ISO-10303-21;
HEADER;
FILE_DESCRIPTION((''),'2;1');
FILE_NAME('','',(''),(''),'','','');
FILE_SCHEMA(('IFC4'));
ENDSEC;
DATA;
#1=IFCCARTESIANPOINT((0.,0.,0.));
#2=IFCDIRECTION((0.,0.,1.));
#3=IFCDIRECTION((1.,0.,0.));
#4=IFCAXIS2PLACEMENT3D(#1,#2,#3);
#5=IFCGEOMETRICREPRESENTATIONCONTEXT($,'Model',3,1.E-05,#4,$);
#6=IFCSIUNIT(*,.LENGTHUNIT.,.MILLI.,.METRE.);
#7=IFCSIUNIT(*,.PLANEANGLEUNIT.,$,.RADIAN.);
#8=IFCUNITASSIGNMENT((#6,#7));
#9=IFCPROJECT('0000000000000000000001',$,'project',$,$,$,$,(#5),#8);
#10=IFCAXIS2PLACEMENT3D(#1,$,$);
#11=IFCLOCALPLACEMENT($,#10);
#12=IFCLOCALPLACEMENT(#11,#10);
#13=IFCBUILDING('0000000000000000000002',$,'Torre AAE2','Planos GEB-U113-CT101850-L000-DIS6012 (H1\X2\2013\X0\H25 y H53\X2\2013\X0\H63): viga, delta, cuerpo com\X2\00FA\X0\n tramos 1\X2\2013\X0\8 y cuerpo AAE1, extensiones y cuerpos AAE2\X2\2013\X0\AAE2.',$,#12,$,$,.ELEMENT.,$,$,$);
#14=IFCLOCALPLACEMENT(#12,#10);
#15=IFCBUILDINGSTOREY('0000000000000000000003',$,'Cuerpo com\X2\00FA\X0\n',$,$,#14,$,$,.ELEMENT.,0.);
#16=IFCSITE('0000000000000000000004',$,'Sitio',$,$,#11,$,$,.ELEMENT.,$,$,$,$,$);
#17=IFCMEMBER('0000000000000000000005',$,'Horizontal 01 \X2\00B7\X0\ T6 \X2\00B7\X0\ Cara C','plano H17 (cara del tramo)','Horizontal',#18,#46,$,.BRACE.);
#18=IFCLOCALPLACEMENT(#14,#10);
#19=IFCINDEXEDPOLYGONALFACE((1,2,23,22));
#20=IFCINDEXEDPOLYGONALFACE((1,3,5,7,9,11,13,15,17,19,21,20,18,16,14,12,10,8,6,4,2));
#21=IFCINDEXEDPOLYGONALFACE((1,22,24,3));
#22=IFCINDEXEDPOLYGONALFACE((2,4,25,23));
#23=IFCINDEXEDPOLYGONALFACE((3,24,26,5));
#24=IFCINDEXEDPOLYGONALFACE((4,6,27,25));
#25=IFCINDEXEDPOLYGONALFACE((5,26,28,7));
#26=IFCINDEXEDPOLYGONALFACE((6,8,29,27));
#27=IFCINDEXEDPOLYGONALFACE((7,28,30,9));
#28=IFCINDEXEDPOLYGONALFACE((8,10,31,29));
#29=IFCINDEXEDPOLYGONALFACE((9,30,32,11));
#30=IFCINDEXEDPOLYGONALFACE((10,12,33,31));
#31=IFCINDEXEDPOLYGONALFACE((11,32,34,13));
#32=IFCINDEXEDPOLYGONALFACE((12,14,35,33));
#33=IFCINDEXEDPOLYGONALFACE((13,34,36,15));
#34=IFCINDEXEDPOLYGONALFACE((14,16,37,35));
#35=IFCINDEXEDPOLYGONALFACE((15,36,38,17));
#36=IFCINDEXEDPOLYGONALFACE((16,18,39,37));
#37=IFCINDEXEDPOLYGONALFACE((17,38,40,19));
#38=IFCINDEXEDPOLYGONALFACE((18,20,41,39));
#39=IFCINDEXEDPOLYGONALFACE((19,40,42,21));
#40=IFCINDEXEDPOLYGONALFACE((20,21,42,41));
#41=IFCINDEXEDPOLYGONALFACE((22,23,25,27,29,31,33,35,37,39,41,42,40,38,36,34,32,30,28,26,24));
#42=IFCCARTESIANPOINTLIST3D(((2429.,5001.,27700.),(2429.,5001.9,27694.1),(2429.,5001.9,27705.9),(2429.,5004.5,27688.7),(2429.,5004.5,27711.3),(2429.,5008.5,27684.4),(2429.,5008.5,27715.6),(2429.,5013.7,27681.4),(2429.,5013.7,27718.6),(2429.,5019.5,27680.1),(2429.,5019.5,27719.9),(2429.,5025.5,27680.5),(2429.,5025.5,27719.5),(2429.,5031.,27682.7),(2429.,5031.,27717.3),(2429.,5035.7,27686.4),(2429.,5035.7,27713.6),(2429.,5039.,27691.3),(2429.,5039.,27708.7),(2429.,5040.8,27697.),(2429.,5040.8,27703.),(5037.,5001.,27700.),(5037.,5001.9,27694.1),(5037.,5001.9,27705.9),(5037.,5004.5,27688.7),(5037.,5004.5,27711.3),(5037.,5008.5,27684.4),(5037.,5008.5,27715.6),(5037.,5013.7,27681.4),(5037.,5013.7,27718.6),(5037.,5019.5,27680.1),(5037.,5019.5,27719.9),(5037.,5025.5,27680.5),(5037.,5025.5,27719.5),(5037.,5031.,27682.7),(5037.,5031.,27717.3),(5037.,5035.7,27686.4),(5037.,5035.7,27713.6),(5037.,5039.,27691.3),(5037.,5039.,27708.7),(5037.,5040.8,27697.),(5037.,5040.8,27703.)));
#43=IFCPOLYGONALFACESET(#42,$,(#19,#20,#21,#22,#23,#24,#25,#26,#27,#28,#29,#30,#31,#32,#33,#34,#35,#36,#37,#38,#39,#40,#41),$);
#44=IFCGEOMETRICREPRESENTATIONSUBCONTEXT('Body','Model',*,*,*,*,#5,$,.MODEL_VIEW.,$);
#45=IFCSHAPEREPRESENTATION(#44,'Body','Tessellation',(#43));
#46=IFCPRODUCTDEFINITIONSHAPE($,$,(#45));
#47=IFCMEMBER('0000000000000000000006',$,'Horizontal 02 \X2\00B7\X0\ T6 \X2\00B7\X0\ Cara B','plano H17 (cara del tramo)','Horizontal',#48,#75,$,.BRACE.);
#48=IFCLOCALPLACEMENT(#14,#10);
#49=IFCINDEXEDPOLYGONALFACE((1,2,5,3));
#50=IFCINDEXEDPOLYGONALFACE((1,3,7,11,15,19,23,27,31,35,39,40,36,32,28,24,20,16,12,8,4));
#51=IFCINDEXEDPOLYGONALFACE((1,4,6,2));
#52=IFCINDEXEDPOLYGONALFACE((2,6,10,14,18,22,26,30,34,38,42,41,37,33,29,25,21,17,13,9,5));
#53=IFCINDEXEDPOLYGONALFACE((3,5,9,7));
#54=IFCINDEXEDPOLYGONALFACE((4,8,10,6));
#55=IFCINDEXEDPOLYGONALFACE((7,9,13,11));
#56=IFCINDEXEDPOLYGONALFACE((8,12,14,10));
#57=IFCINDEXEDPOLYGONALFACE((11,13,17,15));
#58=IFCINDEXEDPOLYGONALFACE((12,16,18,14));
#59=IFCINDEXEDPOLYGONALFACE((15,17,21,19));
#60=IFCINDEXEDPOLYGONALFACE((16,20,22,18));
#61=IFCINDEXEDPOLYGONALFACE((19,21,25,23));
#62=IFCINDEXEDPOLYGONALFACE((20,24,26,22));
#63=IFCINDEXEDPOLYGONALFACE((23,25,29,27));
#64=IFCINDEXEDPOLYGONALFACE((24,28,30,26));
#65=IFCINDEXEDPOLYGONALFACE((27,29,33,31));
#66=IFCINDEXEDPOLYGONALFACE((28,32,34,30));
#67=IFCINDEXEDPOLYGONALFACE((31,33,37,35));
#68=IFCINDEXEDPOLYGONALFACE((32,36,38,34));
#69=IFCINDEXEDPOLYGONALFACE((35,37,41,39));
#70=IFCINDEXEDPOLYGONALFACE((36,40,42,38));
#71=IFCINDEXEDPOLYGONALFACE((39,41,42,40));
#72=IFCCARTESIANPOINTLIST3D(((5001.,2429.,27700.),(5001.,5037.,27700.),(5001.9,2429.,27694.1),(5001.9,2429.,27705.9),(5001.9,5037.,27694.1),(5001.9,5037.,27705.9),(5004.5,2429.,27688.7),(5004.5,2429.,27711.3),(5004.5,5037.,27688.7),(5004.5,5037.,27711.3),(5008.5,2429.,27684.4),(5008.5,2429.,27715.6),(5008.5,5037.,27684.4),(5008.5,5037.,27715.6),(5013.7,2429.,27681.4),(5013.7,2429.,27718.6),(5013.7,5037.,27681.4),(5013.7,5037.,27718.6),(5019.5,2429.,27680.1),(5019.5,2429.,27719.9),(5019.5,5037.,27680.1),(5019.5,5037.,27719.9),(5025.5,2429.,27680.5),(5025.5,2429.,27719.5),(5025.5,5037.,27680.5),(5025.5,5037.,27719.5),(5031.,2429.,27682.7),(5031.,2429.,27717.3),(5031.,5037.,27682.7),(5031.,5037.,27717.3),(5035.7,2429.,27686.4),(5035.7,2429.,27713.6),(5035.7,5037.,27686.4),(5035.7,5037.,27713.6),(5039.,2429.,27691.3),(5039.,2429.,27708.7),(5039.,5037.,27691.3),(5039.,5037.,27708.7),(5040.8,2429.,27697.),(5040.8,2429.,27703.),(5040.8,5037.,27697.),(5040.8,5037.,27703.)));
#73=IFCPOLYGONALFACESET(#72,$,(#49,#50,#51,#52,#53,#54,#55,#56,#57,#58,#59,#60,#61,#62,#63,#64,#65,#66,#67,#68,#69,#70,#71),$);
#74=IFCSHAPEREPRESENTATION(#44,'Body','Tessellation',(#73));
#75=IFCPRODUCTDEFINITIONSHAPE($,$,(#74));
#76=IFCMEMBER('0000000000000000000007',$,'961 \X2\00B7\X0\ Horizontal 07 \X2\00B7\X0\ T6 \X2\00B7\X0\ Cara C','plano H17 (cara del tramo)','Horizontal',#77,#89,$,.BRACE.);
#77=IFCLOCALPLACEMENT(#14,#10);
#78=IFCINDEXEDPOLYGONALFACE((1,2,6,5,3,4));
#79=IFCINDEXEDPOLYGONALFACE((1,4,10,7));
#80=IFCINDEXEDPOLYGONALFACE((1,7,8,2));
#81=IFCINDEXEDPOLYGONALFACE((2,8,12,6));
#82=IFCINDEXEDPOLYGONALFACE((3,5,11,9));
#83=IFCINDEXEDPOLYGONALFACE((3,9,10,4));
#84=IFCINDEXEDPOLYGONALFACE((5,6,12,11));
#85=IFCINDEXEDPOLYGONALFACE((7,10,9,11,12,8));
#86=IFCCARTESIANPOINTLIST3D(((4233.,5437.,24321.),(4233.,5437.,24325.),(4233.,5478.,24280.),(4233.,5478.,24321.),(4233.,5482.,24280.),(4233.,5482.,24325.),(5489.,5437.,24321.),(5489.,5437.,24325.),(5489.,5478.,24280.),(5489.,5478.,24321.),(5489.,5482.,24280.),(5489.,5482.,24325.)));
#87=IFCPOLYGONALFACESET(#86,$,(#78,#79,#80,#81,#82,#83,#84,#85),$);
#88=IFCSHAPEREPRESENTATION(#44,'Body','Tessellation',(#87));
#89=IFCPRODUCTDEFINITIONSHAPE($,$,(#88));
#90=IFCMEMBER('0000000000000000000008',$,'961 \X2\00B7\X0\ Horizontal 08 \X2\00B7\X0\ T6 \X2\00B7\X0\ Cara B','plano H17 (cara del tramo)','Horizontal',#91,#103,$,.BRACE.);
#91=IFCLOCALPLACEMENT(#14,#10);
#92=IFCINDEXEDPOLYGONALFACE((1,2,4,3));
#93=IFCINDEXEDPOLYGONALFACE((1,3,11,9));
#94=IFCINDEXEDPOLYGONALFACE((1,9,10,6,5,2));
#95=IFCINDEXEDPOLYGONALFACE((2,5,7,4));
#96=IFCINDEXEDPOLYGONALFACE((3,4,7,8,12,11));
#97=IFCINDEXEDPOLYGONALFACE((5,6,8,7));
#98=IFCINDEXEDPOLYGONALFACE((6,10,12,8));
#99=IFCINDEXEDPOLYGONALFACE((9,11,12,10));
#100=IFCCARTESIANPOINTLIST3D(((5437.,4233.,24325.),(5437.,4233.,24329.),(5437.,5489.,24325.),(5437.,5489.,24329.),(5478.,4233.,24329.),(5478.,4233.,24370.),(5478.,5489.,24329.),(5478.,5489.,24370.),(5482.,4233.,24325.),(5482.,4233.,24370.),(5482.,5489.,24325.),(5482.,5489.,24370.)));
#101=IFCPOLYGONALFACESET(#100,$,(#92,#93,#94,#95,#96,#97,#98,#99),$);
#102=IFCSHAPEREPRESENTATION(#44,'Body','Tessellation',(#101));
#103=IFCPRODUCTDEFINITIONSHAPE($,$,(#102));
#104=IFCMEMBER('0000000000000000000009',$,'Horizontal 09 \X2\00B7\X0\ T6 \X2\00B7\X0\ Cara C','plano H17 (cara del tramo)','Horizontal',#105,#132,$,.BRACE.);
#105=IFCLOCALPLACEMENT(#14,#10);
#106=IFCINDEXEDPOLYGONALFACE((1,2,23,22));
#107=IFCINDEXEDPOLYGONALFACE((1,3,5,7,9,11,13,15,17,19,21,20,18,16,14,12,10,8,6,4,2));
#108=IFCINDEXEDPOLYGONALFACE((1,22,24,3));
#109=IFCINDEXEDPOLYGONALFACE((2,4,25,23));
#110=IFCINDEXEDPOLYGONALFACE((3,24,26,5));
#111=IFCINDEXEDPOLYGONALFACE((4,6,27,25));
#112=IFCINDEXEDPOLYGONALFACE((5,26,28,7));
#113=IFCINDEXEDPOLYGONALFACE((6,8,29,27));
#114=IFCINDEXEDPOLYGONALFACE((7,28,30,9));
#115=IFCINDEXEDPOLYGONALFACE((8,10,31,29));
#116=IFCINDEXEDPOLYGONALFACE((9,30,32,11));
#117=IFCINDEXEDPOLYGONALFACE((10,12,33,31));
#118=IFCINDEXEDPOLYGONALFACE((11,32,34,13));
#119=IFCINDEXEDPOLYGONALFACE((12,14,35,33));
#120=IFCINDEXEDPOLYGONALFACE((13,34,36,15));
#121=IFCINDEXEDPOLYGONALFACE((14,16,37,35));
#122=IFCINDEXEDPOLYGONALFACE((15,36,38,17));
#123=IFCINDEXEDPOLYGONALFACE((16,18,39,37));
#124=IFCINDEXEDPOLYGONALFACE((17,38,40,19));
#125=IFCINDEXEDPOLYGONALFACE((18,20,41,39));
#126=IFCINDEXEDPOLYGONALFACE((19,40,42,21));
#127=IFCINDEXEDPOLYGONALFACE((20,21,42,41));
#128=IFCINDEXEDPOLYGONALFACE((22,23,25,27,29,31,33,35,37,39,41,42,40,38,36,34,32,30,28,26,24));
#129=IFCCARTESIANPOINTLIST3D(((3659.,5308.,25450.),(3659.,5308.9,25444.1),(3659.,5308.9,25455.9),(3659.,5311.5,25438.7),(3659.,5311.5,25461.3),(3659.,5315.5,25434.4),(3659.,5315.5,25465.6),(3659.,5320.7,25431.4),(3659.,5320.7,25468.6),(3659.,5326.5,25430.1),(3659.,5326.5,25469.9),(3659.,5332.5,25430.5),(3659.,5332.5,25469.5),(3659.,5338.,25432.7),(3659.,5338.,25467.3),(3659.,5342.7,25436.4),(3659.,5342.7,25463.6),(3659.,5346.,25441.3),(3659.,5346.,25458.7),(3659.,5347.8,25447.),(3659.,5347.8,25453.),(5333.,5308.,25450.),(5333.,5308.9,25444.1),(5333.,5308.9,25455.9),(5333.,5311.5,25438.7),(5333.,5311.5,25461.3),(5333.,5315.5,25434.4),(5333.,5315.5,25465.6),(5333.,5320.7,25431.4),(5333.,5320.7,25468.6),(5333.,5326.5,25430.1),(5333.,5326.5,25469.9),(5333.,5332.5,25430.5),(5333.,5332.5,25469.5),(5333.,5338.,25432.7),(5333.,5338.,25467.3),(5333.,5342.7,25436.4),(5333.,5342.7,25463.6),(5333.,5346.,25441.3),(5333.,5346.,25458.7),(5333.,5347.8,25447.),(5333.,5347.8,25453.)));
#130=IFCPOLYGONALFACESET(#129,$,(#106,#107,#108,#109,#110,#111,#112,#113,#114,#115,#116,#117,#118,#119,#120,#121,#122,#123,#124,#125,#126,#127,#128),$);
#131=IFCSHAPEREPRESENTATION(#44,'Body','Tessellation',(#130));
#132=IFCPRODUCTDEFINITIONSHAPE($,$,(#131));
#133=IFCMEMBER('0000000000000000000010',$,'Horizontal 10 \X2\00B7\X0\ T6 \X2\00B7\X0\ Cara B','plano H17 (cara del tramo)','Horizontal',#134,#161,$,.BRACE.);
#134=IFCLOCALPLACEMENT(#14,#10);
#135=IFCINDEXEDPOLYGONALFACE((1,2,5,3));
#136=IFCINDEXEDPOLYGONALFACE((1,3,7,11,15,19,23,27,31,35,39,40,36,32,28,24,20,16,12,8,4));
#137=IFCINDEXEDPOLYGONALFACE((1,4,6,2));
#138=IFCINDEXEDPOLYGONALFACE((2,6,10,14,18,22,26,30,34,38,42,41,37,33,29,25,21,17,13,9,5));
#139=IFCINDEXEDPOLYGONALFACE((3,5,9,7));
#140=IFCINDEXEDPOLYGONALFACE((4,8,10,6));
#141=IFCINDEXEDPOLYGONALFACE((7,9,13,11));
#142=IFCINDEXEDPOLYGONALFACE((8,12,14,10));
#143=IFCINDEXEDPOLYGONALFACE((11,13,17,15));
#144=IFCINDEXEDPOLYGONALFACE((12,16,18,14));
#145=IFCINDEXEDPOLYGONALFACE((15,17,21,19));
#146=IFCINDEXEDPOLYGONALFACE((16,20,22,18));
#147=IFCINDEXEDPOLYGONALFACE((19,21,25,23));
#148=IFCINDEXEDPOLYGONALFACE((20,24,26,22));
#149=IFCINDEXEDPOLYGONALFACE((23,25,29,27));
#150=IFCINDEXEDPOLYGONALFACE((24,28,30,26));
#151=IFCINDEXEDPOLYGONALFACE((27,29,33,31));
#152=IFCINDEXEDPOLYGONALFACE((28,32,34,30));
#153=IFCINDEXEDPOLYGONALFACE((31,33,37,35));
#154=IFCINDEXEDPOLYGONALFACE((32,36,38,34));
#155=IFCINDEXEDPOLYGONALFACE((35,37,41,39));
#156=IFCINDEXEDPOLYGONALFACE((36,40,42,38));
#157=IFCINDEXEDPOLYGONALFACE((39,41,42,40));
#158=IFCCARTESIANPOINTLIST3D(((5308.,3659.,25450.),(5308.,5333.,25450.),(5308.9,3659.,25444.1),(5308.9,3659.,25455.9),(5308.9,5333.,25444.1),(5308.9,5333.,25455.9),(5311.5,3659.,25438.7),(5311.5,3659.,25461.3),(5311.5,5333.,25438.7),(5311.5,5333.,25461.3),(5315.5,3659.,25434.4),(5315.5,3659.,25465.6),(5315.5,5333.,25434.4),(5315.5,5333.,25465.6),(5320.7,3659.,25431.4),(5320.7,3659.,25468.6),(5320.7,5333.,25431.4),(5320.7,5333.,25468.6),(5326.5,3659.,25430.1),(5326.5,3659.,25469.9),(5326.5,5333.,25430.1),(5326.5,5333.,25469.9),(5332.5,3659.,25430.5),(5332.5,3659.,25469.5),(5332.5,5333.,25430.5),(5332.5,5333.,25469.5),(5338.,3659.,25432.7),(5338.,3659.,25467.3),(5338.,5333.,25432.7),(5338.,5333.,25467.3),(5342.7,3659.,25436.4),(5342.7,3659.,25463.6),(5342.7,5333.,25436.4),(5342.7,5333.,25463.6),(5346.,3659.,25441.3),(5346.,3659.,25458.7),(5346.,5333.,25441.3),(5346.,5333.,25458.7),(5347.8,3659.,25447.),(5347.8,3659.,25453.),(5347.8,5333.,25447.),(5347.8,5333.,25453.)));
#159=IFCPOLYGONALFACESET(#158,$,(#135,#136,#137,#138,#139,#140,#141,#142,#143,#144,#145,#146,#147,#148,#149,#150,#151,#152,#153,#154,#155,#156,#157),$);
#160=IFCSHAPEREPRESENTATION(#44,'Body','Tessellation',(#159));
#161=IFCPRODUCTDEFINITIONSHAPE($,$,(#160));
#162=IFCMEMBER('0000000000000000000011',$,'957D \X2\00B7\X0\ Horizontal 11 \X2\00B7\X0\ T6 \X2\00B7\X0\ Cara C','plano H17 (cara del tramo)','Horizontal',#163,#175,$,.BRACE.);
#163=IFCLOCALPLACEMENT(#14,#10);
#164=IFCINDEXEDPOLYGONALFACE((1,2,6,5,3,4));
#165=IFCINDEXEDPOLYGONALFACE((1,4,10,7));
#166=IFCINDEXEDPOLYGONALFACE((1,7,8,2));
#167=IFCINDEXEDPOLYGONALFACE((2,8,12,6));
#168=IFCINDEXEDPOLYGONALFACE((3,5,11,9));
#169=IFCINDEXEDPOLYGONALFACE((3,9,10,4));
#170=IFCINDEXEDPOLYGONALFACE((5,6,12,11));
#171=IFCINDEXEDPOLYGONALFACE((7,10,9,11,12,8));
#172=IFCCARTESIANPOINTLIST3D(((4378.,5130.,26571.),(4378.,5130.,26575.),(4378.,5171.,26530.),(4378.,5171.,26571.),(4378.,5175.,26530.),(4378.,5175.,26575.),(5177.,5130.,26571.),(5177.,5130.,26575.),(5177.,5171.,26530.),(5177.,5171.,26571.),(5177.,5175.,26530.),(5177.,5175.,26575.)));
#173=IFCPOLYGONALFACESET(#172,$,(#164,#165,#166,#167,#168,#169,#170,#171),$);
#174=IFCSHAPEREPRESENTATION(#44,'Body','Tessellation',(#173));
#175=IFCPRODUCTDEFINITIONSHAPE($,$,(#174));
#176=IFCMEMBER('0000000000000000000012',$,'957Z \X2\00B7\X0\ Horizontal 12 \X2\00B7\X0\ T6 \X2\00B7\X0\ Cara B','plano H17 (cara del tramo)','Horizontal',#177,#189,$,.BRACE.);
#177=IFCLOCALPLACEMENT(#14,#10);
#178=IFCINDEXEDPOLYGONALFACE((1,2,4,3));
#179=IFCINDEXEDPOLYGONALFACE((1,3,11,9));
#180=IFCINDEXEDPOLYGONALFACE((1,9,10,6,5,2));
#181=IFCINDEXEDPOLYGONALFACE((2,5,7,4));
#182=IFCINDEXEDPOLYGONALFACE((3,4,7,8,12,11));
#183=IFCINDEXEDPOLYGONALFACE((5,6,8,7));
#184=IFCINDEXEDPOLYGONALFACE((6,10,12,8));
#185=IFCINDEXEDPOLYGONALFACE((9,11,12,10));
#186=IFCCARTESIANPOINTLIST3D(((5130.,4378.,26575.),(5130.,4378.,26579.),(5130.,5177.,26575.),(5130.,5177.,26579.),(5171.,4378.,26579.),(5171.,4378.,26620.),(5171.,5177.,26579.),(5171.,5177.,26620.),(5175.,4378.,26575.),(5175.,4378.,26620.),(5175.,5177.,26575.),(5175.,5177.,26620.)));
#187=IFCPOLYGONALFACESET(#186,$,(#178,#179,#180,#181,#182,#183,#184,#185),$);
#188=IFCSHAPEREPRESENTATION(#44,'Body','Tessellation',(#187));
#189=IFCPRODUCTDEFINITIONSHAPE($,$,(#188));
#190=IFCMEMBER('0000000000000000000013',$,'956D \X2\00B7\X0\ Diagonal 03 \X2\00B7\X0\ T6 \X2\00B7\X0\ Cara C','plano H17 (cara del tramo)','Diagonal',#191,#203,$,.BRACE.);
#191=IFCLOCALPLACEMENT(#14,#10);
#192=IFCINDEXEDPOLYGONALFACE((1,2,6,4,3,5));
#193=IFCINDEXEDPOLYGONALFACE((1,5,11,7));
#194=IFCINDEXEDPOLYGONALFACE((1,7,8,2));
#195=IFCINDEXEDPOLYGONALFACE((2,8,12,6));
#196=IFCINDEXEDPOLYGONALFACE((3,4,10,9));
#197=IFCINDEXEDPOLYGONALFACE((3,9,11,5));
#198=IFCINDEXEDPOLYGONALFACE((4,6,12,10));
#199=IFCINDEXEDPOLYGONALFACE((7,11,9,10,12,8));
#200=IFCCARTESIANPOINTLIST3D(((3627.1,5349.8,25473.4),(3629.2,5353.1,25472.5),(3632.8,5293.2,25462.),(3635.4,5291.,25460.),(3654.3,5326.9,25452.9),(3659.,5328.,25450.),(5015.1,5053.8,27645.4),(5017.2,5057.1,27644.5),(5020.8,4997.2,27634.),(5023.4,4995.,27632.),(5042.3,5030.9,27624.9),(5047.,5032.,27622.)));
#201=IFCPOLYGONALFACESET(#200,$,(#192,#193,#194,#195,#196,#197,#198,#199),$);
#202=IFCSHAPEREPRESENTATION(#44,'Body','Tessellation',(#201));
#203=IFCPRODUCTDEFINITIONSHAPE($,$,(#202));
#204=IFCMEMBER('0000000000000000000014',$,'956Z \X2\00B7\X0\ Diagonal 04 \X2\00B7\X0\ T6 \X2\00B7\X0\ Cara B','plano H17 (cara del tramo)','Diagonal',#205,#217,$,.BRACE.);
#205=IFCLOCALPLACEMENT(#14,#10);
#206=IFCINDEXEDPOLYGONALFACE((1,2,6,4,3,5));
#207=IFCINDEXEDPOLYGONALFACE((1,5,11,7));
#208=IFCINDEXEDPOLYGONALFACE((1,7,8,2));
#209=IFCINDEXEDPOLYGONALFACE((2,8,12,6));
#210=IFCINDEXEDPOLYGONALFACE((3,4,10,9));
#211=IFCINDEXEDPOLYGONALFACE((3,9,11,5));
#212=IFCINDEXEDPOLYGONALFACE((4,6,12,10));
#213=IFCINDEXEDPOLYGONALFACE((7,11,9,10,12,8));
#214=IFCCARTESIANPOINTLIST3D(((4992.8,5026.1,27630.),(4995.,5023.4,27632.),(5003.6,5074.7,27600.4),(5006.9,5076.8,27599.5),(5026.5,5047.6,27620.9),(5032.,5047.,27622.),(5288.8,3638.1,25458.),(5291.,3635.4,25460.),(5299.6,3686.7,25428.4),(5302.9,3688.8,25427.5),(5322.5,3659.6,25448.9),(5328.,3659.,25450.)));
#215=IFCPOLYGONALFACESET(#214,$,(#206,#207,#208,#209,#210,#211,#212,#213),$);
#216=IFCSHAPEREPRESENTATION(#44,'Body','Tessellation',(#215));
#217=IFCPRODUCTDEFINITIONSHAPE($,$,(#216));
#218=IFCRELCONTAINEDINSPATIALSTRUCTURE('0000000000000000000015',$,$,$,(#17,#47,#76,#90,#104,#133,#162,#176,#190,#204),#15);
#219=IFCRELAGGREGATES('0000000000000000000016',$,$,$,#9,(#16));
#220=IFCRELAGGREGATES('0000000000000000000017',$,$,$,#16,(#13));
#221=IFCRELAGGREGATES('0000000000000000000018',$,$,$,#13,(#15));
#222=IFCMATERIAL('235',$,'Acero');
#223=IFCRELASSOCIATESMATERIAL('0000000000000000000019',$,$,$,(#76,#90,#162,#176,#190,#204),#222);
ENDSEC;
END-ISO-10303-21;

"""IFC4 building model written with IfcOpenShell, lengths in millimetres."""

from ifc_helpers import new_model, si_unit, frame, frame_2d, origin, origin_with_axes, place, context, subcontext, project, spatial, circle, l_section, extrude, material, element, save


model = new_model("IFC4")

# Units and contexts
model_context = context("Model", 3, precision=1e-05, world=origin_with_axes())
body_context = subcontext(model_context, "Body", "Model", "MODEL_VIEW")
ifc_project = project(units=[si_unit("LENGTHUNIT", "METRE", prefix="MILLI"), si_unit("PLANEANGLEUNIT", "RADIAN")], contexts=[model_context])

# Site, building, storey
site_placement = place(None, origin())
site = spatial("IfcSite", under=ifc_project, at=site_placement, Name="Sitio", CompositionType="ELEMENT")
building_placement = place(site_placement, origin())
building = spatial("IfcBuilding", under=site, at=building_placement, Name="Torre AAE2", Description="Planos GEB-U113-CT101850-L000-DIS6012 (H1–H25 y H53–H63): viga, delta, cuerpo común tramos 1–8 y cuerpo AAE1, extensiones y cuerpos AAE2–AAE2.", CompositionType="ELEMENT")
storey_placement = place(building_placement, origin())
storey = spatial("IfcBuildingStorey", under=building, at=storey_placement, Name="Cuerpo común", CompositionType="ELEMENT", Elevation=0.0)

# Members
for number, where, z_axis, x_axis, name in (
    (1, (5037.0, 5021.0, 27700.0), (-1.0, 0.0, 0.0), (0.0, -1.0, 0.0), "Horizontal 01 · T6 · Cara C"),
    (2, (5021.0, 5037.0, 27700.0), (0.0, -1.0, 0.0), (-1.0, 0.0, 0.0), "Horizontal 02 · T6 · Cara B"),
):
    element("IfcMember", number, at=place(storey_placement, frame(where, z_axis=z_axis, x_axis=x_axis)), inside=storey, Name=name, Description="plano H17 (cara del tramo)", ObjectType="Horizontal", PredefinedType="BRACE", context=body_context, shape_type="SweptSolid", body=[
        extrude(circle(Radius=20.0), None, (0.0, 0.0, 1.0), 2608.0),
    ])
ifc_material_1 = material(Name="235", Category="Acero")
for number, where, z_axis, x_axis, name in (
    (3, (4233.0, 5482.0, 24325.0), (1.0, 0.0, 0.0), (0.0, -1.0, 0.0), "961 · Horizontal 07 · T6 · Cara C"),
    (4, (5482.0, 4233.0, 24325.0), (0.0, 1.0, 0.0), (-1.0, 0.0, 0.0), "961 · Horizontal 08 · T6 · Cara B"),
):
    element("IfcMember", number, at=place(storey_placement, frame(where, z_axis=z_axis, x_axis=x_axis)), inside=storey, material=ifc_material_1, Name=name, Description="plano H17 (cara del tramo)", ObjectType="Horizontal", PredefinedType="BRACE", context=body_context, shape_type="SweptSolid", body=[
        extrude(l_section(Depth=45.0, Width=45.0, Thickness=4.0, at=frame_2d((22.5, 22.5))), None, (0.0, 0.0, 1.0), 1256.0),
    ])
for number, where, z_axis, x_axis, name in (
    (5, (3659.0, 5328.0, 25450.0), (1.0, 0.0, 0.0), (0.0, -1.0, 0.0), "Horizontal 09 · T6 · Cara C"),
    (6, (5328.0, 3659.0, 25450.0), (0.0, 1.0, 0.0), (-1.0, 0.0, 0.0), "Horizontal 10 · T6 · Cara B"),
):
    element("IfcMember", number, at=place(storey_placement, frame(where, z_axis=z_axis, x_axis=x_axis)), inside=storey, Name=name, Description="plano H17 (cara del tramo)", ObjectType="Horizontal", PredefinedType="BRACE", context=body_context, shape_type="SweptSolid", body=[
        extrude(circle(Radius=20.0), None, (0.0, 0.0, 1.0), 1674.0),
    ])
for number, where, z_axis, x_axis, name in (
    (7, (4378.0, 5175.0, 26575.0), (1.0, 0.0, 0.0), (0.0, -1.0, 0.0), "957D · Horizontal 11 · T6 · Cara C"),
    (8, (5175.0, 4378.0, 26575.0), (0.0, 1.0, 0.0), (-1.0, 0.0, 0.0), "957Z · Horizontal 12 · T6 · Cara B"),
):
    element("IfcMember", number, at=place(storey_placement, frame(where, z_axis=z_axis, x_axis=x_axis)), inside=storey, material=ifc_material_1, Name=name, Description="plano H17 (cara del tramo)", ObjectType="Horizontal", PredefinedType="BRACE", context=body_context, shape_type="SweptSolid", body=[
        extrude(l_section(Depth=45.0, Width=45.0, Thickness=4.0, at=frame_2d((22.5, 22.5))), None, (0.0, 0.0, 1.0), 799.0),
    ])
for number, where, z_axis, x_axis, name in (
    (9, (5047.0, 5032.0, 27622.0), (-0.534965, 0.114085, -0.837136), (-0.523514, -0.822462, 0.222463), "956D · Diagonal 03 · T6 · Cara C"),
    (10, (5032.0, 5047.0, 27622.0), (0.114085, -0.534965, -0.837136), (-0.822462, -0.523514, 0.222463), "956Z · Diagonal 04 · T6 · Cara B"),
):
    element("IfcMember", number, at=place(storey_placement, frame(where, z_axis=z_axis, x_axis=x_axis)), inside=storey, material=ifc_material_1, Name=name, Description="plano H17 (cara del tramo)", ObjectType="Diagonal", PredefinedType="BRACE", context=body_context, shape_type="SweptSolid", body=[
        extrude(l_section(Depth=45.0, Width=45.0, Thickness=4.0, at=frame_2d((22.5, 22.5))), None, (0.0, 0.0, 1.0), 2594.6),
    ])

save(model, "model.ifc")
